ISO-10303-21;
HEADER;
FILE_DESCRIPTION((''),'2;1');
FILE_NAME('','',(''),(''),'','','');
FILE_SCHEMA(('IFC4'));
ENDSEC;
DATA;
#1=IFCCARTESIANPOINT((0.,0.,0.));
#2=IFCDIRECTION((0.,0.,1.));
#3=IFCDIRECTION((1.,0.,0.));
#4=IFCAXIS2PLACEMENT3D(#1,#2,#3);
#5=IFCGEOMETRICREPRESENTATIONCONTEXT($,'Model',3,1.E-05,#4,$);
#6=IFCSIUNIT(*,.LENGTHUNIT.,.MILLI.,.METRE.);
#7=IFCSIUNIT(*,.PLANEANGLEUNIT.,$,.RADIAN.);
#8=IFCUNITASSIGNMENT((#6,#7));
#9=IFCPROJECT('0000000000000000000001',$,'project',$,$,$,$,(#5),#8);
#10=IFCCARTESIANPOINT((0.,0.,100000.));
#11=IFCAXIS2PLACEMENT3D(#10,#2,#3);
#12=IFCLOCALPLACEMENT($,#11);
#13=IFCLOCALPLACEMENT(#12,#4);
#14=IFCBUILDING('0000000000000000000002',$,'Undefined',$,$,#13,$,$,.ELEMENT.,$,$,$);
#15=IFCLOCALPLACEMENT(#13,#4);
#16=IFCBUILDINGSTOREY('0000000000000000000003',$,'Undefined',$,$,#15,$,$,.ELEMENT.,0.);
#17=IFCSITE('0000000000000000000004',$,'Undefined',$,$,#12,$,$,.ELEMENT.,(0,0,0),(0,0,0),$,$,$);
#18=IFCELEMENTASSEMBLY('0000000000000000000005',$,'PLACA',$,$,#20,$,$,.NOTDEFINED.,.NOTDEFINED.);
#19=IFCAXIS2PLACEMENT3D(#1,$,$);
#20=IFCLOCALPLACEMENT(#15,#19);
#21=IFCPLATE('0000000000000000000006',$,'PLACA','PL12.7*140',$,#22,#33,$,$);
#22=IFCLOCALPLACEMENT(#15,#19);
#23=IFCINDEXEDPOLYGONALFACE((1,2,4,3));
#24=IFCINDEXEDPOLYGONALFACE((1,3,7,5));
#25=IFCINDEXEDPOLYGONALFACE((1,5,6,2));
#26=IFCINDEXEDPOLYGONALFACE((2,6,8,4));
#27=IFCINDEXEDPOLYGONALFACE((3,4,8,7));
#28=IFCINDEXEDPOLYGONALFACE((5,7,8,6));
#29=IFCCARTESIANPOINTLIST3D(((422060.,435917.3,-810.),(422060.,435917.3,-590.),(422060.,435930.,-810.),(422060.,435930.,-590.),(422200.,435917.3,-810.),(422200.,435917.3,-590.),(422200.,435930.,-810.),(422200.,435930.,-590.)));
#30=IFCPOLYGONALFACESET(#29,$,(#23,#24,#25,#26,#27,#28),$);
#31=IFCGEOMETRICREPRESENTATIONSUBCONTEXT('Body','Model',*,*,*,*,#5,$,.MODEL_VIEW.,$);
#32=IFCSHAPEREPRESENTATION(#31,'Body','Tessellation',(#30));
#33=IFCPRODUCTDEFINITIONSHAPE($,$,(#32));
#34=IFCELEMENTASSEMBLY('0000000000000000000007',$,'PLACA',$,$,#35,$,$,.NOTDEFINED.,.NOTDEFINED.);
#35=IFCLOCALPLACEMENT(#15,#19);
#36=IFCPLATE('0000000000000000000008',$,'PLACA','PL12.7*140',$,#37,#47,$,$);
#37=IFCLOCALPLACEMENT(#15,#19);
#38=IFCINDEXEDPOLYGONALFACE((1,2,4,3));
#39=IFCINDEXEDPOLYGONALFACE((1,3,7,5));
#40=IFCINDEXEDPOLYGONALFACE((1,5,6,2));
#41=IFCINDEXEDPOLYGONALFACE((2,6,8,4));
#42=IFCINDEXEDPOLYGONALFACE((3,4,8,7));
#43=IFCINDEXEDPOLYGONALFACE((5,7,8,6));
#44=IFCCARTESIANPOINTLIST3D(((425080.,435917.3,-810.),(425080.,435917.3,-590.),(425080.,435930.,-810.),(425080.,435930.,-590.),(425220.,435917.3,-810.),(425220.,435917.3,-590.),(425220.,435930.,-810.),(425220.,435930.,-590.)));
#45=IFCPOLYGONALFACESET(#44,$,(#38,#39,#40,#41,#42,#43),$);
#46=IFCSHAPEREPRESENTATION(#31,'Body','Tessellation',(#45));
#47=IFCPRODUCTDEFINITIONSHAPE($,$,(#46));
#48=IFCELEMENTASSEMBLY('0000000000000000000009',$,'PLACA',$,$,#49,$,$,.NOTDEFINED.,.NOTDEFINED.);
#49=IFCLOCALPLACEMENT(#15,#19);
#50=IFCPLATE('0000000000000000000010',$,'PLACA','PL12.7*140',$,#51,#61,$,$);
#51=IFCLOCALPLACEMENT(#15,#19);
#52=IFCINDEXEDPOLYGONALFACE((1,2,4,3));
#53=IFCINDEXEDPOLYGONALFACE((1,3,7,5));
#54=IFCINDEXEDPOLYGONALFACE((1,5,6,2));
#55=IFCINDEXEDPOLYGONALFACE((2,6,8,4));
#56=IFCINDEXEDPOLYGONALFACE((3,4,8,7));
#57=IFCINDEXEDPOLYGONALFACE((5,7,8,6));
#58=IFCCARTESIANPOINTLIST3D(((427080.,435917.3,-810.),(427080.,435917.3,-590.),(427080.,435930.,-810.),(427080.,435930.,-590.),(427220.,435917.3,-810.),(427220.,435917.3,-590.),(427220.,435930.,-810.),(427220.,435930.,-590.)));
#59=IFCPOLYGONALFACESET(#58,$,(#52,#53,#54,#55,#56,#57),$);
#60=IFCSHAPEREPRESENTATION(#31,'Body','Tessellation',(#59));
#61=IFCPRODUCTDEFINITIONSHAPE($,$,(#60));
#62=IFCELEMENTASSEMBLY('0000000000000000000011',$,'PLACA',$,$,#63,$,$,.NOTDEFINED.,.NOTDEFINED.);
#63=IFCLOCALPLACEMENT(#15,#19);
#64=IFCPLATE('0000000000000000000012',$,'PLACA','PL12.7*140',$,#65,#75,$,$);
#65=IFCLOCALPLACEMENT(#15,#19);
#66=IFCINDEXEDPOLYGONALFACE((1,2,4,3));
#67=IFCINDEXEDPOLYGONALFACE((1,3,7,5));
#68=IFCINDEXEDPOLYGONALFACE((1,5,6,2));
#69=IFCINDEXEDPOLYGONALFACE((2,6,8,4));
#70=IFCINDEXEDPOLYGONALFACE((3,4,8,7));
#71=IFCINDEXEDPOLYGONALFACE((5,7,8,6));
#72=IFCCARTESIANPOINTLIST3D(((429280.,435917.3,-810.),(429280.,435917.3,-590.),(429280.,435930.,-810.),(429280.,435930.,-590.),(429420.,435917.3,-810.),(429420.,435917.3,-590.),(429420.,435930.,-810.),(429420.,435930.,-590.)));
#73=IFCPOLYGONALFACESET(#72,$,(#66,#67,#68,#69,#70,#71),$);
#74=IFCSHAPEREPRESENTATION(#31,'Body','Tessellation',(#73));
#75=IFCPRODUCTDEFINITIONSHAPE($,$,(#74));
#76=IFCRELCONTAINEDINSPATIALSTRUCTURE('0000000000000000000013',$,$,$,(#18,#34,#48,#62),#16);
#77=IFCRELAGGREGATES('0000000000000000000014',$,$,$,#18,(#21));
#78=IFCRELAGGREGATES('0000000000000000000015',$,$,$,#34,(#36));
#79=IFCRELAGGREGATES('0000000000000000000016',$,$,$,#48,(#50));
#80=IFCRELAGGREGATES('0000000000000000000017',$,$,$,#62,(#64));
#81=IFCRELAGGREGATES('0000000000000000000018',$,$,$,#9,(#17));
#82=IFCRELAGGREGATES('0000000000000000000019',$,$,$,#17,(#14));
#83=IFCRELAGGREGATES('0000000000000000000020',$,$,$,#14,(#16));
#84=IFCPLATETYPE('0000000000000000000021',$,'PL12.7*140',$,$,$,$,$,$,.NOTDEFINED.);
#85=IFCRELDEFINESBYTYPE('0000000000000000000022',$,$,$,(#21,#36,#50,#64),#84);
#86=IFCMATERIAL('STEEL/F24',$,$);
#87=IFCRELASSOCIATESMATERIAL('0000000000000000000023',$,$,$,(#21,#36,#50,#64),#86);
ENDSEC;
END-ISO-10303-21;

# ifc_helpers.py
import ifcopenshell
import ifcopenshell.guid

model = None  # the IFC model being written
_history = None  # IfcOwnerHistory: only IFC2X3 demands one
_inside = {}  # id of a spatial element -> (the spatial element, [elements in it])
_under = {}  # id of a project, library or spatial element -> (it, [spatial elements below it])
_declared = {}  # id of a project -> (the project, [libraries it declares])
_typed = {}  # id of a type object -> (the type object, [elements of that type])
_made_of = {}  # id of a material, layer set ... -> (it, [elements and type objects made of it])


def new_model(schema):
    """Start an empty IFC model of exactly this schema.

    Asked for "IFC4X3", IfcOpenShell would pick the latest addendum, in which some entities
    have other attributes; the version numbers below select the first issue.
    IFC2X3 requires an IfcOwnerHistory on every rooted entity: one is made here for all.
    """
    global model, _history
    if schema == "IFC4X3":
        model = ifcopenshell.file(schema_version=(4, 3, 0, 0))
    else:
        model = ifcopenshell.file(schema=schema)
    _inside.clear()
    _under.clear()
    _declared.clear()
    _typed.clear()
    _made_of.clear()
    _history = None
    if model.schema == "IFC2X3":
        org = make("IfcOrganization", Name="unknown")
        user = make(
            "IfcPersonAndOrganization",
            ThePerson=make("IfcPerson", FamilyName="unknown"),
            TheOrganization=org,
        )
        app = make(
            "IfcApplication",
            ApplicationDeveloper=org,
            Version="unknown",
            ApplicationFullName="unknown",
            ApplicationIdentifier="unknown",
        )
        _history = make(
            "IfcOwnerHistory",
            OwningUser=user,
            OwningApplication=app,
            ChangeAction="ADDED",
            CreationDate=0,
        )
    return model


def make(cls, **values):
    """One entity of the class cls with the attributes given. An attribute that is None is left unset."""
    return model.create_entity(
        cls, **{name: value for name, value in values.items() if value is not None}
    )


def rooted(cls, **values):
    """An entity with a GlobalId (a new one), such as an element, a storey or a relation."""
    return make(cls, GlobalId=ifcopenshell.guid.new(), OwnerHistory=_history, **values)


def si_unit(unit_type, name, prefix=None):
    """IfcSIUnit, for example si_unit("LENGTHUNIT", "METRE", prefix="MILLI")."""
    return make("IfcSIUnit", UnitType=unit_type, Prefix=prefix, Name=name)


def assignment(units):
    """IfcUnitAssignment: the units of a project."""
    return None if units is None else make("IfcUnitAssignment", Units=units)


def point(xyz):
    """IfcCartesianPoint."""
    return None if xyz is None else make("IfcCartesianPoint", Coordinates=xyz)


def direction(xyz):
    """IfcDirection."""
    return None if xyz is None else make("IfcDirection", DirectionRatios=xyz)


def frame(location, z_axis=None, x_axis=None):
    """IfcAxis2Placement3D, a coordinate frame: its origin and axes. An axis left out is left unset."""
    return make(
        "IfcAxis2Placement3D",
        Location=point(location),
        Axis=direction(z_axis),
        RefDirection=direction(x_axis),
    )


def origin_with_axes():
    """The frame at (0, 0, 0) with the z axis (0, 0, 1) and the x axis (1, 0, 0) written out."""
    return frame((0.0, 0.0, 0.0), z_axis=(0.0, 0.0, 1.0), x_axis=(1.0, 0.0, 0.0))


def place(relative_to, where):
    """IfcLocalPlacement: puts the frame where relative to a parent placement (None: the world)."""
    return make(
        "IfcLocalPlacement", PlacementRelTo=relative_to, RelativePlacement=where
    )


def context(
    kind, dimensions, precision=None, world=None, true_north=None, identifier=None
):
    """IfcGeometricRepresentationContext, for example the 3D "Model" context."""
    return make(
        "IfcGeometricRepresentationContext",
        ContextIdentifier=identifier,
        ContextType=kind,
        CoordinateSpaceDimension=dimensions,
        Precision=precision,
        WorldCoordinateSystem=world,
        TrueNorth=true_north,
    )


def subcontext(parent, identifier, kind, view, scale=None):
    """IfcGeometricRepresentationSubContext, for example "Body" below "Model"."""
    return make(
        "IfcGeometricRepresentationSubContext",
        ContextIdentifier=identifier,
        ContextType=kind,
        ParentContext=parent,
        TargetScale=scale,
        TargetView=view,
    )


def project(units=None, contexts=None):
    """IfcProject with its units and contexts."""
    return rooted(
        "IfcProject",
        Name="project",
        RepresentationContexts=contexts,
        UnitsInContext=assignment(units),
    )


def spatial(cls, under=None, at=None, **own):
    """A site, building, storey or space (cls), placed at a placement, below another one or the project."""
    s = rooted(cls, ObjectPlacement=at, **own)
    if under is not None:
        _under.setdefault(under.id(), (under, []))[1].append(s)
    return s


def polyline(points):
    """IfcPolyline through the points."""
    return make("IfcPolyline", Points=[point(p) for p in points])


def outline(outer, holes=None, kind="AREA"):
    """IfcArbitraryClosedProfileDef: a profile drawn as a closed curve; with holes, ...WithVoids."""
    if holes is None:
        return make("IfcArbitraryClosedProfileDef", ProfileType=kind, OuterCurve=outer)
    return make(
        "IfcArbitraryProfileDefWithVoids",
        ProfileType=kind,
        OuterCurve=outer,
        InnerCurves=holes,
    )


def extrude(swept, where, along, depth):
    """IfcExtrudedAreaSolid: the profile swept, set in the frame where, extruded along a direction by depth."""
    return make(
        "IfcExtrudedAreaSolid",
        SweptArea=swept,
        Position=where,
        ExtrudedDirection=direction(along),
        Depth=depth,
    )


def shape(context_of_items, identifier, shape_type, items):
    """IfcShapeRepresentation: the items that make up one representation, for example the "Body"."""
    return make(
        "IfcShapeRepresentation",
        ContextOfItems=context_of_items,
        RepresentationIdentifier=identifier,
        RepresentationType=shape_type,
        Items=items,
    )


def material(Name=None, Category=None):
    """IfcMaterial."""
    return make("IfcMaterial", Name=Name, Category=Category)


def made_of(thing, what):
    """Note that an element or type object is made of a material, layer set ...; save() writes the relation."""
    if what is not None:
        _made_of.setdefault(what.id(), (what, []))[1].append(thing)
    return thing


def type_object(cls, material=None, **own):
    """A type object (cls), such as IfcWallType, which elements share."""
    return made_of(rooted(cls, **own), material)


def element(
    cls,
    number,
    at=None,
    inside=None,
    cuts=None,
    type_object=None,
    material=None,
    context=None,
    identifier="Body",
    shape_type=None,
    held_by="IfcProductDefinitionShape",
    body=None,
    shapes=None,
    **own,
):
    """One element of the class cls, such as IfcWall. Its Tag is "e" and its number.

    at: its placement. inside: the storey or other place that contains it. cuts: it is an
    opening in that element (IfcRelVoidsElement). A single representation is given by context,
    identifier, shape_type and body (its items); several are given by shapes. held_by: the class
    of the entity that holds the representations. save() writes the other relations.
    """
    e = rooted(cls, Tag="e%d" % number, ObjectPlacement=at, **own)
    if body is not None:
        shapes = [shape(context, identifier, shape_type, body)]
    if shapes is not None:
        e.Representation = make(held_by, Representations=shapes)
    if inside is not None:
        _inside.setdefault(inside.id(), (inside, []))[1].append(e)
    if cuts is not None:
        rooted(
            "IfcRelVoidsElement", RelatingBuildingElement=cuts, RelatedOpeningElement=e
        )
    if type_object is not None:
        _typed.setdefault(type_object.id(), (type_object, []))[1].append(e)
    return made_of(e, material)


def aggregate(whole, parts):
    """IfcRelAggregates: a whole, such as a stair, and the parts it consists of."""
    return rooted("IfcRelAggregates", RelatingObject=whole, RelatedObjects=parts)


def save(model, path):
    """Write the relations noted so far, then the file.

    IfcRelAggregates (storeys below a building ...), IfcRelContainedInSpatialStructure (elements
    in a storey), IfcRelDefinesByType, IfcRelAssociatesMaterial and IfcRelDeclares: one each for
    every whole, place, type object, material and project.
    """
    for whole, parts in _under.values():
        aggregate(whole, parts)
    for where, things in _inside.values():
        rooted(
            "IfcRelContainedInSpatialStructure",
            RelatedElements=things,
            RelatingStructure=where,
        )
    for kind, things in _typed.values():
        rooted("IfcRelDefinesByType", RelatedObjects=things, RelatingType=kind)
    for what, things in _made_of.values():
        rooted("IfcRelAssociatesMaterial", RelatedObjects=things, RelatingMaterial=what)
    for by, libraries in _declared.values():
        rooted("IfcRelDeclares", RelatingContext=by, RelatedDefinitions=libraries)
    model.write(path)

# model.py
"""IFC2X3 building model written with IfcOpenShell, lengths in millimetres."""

from ifc_helpers import new_model, si_unit, frame, origin_with_axes, place, context, subcontext, project, spatial, polyline, outline, extrude, material, type_object, element, aggregate, save


model = new_model("IFC2X3")

# Units and contexts
model_context = context("Model", 3, precision=1e-05, world=origin_with_axes())
body_context = subcontext(model_context, "Body", "Model", "MODEL_VIEW")
ifc_project = project(units=[si_unit("LENGTHUNIT", "METRE", prefix="MILLI"), si_unit("PLANEANGLEUNIT", "RADIAN")], contexts=[model_context])

# Site, building, storey
site_placement = place(None, frame((0.0, 0.0, 100000.0), z_axis=(0.0, 0.0, 1.0), x_axis=(1.0, 0.0, 0.0)))
site = spatial("IfcSite", under=ifc_project, at=site_placement, Name="Undefined", CompositionType="ELEMENT", RefLatitude=(0, 0, 0), RefLongitude=(0, 0, 0))
building_placement = place(site_placement, origin_with_axes())
building = spatial("IfcBuilding", under=site, at=building_placement, Name="Undefined", CompositionType="ELEMENT")
storey_placement = place(building_placement, origin_with_axes())
storey = spatial("IfcBuildingStorey", under=building, at=storey_placement, Name="Undefined", CompositionType="ELEMENT", Elevation=0.0)

# Element assemblies, plates
assembly_1_placement = place(storey_placement, origin_with_axes())
assembly_1 = element("IfcElementAssembly", 1, at=assembly_1_placement, inside=storey, Name="PLACA", AssemblyPlace="NOTDEFINED", PredefinedType="NOTDEFINED")
ifc_material_1 = material(Name="STEEL/F24")
plate_type = type_object("IfcPlateType", Name="PL12.7*140", PredefinedType="NOTDEFINED")
plate_1_placement = place(assembly_1_placement, frame((422060.0, 435923.6, -590.0), z_axis=(0.0, 1.0, 0.0), x_axis=(1.0, 0.0, 0.0)))
plate_1 = element("IfcPlate", 2, at=plate_1_placement, type_object=plate_type, material=ifc_material_1, Name="PLACA", Description="PL12.7*140", context=body_context, shape_type="SweptSolid", body=[
    extrude(outline(polyline([(0.0, 0.0), (140.0, 0.0), (140.0, 220.0), (0.0, 220.0), (0.0, 0.0)])), frame((0.0, 0.0, -6.3), z_axis=(0.0, 0.0, 1.0), x_axis=(1.0, 0.0, 0.0)), (0.0, 0.0, 1.0), 12.7),
])
aggregate(assembly_1, [plate_1])
assembly_2_placement = place(storey_placement, origin_with_axes())
assembly_2 = element("IfcElementAssembly", 3, at=assembly_2_placement, inside=storey, Name="PLACA", AssemblyPlace="NOTDEFINED", PredefinedType="NOTDEFINED")
plate_2_placement = place(assembly_2_placement, frame((425080.0, 435923.6, -590.0), z_axis=(0.0, 1.0, 0.0), x_axis=(1.0, 0.0, 0.0)))
plate_2 = element("IfcPlate", 4, at=plate_2_placement, type_object=plate_type, material=ifc_material_1, Name="PLACA", Description="PL12.7*140", context=body_context, shape_type="SweptSolid", body=[
    extrude(outline(polyline([(0.0, 0.0), (140.0, 0.0), (140.0, 220.0), (0.0, 220.0), (0.0, 0.0)])), frame((0.0, 0.0, -6.3), z_axis=(0.0, 0.0, 1.0), x_axis=(1.0, 0.0, 0.0)), (0.0, 0.0, 1.0), 12.7),
])
aggregate(assembly_2, [plate_2])
assembly_3_placement = place(storey_placement, origin_with_axes())
assembly_3 = element("IfcElementAssembly", 5, at=assembly_3_placement, inside=storey, Name="PLACA", AssemblyPlace="NOTDEFINED", PredefinedType="NOTDEFINED")
plate_3_placement = place(assembly_3_placement, frame((427080.0, 435923.6, -590.0), z_axis=(0.0, 1.0, 0.0), x_axis=(1.0, 0.0, 0.0)))
plate_3 = element("IfcPlate", 6, at=plate_3_placement, type_object=plate_type, material=ifc_material_1, Name="PLACA", Description="PL12.7*140", context=body_context, shape_type="SweptSolid", body=[
    extrude(outline(polyline([(0.0, 0.0), (140.0, 0.0), (140.0, 220.0), (0.0, 220.0), (0.0, 0.0)])), frame((0.0, 0.0, -6.3), z_axis=(0.0, 0.0, 1.0), x_axis=(1.0, 0.0, 0.0)), (0.0, 0.0, 1.0), 12.7),
])
aggregate(assembly_3, [plate_3])
assembly_4_placement = place(storey_placement, origin_with_axes())
assembly_4 = element("IfcElementAssembly", 7, at=assembly_4_placement, inside=storey, Name="PLACA", AssemblyPlace="NOTDEFINED", PredefinedType="NOTDEFINED")
plate_4_placement = place(assembly_4_placement, frame((429280.0, 435923.6, -590.0), z_axis=(0.0, 1.0, 0.0), x_axis=(1.0, 0.0, 0.0)))
plate_4 = element("IfcPlate", 8, at=plate_4_placement, type_object=plate_type, material=ifc_material_1, Name="PLACA", Description="PL12.7*140", context=body_context, shape_type="SweptSolid", body=[
    extrude(outline(polyline([(0.0, 0.0), (140.0, 0.0), (140.0, 220.0), (0.0, 220.0), (0.0, 0.0)])), frame((0.0, 0.0, -6.3), z_axis=(0.0, 0.0, 1.0), x_axis=(1.0, 0.0, 0.0)), (0.0, 0.0, 1.0), 12.7),
])
aggregate(assembly_4, [plate_4])

save(model, "model.ifc")
